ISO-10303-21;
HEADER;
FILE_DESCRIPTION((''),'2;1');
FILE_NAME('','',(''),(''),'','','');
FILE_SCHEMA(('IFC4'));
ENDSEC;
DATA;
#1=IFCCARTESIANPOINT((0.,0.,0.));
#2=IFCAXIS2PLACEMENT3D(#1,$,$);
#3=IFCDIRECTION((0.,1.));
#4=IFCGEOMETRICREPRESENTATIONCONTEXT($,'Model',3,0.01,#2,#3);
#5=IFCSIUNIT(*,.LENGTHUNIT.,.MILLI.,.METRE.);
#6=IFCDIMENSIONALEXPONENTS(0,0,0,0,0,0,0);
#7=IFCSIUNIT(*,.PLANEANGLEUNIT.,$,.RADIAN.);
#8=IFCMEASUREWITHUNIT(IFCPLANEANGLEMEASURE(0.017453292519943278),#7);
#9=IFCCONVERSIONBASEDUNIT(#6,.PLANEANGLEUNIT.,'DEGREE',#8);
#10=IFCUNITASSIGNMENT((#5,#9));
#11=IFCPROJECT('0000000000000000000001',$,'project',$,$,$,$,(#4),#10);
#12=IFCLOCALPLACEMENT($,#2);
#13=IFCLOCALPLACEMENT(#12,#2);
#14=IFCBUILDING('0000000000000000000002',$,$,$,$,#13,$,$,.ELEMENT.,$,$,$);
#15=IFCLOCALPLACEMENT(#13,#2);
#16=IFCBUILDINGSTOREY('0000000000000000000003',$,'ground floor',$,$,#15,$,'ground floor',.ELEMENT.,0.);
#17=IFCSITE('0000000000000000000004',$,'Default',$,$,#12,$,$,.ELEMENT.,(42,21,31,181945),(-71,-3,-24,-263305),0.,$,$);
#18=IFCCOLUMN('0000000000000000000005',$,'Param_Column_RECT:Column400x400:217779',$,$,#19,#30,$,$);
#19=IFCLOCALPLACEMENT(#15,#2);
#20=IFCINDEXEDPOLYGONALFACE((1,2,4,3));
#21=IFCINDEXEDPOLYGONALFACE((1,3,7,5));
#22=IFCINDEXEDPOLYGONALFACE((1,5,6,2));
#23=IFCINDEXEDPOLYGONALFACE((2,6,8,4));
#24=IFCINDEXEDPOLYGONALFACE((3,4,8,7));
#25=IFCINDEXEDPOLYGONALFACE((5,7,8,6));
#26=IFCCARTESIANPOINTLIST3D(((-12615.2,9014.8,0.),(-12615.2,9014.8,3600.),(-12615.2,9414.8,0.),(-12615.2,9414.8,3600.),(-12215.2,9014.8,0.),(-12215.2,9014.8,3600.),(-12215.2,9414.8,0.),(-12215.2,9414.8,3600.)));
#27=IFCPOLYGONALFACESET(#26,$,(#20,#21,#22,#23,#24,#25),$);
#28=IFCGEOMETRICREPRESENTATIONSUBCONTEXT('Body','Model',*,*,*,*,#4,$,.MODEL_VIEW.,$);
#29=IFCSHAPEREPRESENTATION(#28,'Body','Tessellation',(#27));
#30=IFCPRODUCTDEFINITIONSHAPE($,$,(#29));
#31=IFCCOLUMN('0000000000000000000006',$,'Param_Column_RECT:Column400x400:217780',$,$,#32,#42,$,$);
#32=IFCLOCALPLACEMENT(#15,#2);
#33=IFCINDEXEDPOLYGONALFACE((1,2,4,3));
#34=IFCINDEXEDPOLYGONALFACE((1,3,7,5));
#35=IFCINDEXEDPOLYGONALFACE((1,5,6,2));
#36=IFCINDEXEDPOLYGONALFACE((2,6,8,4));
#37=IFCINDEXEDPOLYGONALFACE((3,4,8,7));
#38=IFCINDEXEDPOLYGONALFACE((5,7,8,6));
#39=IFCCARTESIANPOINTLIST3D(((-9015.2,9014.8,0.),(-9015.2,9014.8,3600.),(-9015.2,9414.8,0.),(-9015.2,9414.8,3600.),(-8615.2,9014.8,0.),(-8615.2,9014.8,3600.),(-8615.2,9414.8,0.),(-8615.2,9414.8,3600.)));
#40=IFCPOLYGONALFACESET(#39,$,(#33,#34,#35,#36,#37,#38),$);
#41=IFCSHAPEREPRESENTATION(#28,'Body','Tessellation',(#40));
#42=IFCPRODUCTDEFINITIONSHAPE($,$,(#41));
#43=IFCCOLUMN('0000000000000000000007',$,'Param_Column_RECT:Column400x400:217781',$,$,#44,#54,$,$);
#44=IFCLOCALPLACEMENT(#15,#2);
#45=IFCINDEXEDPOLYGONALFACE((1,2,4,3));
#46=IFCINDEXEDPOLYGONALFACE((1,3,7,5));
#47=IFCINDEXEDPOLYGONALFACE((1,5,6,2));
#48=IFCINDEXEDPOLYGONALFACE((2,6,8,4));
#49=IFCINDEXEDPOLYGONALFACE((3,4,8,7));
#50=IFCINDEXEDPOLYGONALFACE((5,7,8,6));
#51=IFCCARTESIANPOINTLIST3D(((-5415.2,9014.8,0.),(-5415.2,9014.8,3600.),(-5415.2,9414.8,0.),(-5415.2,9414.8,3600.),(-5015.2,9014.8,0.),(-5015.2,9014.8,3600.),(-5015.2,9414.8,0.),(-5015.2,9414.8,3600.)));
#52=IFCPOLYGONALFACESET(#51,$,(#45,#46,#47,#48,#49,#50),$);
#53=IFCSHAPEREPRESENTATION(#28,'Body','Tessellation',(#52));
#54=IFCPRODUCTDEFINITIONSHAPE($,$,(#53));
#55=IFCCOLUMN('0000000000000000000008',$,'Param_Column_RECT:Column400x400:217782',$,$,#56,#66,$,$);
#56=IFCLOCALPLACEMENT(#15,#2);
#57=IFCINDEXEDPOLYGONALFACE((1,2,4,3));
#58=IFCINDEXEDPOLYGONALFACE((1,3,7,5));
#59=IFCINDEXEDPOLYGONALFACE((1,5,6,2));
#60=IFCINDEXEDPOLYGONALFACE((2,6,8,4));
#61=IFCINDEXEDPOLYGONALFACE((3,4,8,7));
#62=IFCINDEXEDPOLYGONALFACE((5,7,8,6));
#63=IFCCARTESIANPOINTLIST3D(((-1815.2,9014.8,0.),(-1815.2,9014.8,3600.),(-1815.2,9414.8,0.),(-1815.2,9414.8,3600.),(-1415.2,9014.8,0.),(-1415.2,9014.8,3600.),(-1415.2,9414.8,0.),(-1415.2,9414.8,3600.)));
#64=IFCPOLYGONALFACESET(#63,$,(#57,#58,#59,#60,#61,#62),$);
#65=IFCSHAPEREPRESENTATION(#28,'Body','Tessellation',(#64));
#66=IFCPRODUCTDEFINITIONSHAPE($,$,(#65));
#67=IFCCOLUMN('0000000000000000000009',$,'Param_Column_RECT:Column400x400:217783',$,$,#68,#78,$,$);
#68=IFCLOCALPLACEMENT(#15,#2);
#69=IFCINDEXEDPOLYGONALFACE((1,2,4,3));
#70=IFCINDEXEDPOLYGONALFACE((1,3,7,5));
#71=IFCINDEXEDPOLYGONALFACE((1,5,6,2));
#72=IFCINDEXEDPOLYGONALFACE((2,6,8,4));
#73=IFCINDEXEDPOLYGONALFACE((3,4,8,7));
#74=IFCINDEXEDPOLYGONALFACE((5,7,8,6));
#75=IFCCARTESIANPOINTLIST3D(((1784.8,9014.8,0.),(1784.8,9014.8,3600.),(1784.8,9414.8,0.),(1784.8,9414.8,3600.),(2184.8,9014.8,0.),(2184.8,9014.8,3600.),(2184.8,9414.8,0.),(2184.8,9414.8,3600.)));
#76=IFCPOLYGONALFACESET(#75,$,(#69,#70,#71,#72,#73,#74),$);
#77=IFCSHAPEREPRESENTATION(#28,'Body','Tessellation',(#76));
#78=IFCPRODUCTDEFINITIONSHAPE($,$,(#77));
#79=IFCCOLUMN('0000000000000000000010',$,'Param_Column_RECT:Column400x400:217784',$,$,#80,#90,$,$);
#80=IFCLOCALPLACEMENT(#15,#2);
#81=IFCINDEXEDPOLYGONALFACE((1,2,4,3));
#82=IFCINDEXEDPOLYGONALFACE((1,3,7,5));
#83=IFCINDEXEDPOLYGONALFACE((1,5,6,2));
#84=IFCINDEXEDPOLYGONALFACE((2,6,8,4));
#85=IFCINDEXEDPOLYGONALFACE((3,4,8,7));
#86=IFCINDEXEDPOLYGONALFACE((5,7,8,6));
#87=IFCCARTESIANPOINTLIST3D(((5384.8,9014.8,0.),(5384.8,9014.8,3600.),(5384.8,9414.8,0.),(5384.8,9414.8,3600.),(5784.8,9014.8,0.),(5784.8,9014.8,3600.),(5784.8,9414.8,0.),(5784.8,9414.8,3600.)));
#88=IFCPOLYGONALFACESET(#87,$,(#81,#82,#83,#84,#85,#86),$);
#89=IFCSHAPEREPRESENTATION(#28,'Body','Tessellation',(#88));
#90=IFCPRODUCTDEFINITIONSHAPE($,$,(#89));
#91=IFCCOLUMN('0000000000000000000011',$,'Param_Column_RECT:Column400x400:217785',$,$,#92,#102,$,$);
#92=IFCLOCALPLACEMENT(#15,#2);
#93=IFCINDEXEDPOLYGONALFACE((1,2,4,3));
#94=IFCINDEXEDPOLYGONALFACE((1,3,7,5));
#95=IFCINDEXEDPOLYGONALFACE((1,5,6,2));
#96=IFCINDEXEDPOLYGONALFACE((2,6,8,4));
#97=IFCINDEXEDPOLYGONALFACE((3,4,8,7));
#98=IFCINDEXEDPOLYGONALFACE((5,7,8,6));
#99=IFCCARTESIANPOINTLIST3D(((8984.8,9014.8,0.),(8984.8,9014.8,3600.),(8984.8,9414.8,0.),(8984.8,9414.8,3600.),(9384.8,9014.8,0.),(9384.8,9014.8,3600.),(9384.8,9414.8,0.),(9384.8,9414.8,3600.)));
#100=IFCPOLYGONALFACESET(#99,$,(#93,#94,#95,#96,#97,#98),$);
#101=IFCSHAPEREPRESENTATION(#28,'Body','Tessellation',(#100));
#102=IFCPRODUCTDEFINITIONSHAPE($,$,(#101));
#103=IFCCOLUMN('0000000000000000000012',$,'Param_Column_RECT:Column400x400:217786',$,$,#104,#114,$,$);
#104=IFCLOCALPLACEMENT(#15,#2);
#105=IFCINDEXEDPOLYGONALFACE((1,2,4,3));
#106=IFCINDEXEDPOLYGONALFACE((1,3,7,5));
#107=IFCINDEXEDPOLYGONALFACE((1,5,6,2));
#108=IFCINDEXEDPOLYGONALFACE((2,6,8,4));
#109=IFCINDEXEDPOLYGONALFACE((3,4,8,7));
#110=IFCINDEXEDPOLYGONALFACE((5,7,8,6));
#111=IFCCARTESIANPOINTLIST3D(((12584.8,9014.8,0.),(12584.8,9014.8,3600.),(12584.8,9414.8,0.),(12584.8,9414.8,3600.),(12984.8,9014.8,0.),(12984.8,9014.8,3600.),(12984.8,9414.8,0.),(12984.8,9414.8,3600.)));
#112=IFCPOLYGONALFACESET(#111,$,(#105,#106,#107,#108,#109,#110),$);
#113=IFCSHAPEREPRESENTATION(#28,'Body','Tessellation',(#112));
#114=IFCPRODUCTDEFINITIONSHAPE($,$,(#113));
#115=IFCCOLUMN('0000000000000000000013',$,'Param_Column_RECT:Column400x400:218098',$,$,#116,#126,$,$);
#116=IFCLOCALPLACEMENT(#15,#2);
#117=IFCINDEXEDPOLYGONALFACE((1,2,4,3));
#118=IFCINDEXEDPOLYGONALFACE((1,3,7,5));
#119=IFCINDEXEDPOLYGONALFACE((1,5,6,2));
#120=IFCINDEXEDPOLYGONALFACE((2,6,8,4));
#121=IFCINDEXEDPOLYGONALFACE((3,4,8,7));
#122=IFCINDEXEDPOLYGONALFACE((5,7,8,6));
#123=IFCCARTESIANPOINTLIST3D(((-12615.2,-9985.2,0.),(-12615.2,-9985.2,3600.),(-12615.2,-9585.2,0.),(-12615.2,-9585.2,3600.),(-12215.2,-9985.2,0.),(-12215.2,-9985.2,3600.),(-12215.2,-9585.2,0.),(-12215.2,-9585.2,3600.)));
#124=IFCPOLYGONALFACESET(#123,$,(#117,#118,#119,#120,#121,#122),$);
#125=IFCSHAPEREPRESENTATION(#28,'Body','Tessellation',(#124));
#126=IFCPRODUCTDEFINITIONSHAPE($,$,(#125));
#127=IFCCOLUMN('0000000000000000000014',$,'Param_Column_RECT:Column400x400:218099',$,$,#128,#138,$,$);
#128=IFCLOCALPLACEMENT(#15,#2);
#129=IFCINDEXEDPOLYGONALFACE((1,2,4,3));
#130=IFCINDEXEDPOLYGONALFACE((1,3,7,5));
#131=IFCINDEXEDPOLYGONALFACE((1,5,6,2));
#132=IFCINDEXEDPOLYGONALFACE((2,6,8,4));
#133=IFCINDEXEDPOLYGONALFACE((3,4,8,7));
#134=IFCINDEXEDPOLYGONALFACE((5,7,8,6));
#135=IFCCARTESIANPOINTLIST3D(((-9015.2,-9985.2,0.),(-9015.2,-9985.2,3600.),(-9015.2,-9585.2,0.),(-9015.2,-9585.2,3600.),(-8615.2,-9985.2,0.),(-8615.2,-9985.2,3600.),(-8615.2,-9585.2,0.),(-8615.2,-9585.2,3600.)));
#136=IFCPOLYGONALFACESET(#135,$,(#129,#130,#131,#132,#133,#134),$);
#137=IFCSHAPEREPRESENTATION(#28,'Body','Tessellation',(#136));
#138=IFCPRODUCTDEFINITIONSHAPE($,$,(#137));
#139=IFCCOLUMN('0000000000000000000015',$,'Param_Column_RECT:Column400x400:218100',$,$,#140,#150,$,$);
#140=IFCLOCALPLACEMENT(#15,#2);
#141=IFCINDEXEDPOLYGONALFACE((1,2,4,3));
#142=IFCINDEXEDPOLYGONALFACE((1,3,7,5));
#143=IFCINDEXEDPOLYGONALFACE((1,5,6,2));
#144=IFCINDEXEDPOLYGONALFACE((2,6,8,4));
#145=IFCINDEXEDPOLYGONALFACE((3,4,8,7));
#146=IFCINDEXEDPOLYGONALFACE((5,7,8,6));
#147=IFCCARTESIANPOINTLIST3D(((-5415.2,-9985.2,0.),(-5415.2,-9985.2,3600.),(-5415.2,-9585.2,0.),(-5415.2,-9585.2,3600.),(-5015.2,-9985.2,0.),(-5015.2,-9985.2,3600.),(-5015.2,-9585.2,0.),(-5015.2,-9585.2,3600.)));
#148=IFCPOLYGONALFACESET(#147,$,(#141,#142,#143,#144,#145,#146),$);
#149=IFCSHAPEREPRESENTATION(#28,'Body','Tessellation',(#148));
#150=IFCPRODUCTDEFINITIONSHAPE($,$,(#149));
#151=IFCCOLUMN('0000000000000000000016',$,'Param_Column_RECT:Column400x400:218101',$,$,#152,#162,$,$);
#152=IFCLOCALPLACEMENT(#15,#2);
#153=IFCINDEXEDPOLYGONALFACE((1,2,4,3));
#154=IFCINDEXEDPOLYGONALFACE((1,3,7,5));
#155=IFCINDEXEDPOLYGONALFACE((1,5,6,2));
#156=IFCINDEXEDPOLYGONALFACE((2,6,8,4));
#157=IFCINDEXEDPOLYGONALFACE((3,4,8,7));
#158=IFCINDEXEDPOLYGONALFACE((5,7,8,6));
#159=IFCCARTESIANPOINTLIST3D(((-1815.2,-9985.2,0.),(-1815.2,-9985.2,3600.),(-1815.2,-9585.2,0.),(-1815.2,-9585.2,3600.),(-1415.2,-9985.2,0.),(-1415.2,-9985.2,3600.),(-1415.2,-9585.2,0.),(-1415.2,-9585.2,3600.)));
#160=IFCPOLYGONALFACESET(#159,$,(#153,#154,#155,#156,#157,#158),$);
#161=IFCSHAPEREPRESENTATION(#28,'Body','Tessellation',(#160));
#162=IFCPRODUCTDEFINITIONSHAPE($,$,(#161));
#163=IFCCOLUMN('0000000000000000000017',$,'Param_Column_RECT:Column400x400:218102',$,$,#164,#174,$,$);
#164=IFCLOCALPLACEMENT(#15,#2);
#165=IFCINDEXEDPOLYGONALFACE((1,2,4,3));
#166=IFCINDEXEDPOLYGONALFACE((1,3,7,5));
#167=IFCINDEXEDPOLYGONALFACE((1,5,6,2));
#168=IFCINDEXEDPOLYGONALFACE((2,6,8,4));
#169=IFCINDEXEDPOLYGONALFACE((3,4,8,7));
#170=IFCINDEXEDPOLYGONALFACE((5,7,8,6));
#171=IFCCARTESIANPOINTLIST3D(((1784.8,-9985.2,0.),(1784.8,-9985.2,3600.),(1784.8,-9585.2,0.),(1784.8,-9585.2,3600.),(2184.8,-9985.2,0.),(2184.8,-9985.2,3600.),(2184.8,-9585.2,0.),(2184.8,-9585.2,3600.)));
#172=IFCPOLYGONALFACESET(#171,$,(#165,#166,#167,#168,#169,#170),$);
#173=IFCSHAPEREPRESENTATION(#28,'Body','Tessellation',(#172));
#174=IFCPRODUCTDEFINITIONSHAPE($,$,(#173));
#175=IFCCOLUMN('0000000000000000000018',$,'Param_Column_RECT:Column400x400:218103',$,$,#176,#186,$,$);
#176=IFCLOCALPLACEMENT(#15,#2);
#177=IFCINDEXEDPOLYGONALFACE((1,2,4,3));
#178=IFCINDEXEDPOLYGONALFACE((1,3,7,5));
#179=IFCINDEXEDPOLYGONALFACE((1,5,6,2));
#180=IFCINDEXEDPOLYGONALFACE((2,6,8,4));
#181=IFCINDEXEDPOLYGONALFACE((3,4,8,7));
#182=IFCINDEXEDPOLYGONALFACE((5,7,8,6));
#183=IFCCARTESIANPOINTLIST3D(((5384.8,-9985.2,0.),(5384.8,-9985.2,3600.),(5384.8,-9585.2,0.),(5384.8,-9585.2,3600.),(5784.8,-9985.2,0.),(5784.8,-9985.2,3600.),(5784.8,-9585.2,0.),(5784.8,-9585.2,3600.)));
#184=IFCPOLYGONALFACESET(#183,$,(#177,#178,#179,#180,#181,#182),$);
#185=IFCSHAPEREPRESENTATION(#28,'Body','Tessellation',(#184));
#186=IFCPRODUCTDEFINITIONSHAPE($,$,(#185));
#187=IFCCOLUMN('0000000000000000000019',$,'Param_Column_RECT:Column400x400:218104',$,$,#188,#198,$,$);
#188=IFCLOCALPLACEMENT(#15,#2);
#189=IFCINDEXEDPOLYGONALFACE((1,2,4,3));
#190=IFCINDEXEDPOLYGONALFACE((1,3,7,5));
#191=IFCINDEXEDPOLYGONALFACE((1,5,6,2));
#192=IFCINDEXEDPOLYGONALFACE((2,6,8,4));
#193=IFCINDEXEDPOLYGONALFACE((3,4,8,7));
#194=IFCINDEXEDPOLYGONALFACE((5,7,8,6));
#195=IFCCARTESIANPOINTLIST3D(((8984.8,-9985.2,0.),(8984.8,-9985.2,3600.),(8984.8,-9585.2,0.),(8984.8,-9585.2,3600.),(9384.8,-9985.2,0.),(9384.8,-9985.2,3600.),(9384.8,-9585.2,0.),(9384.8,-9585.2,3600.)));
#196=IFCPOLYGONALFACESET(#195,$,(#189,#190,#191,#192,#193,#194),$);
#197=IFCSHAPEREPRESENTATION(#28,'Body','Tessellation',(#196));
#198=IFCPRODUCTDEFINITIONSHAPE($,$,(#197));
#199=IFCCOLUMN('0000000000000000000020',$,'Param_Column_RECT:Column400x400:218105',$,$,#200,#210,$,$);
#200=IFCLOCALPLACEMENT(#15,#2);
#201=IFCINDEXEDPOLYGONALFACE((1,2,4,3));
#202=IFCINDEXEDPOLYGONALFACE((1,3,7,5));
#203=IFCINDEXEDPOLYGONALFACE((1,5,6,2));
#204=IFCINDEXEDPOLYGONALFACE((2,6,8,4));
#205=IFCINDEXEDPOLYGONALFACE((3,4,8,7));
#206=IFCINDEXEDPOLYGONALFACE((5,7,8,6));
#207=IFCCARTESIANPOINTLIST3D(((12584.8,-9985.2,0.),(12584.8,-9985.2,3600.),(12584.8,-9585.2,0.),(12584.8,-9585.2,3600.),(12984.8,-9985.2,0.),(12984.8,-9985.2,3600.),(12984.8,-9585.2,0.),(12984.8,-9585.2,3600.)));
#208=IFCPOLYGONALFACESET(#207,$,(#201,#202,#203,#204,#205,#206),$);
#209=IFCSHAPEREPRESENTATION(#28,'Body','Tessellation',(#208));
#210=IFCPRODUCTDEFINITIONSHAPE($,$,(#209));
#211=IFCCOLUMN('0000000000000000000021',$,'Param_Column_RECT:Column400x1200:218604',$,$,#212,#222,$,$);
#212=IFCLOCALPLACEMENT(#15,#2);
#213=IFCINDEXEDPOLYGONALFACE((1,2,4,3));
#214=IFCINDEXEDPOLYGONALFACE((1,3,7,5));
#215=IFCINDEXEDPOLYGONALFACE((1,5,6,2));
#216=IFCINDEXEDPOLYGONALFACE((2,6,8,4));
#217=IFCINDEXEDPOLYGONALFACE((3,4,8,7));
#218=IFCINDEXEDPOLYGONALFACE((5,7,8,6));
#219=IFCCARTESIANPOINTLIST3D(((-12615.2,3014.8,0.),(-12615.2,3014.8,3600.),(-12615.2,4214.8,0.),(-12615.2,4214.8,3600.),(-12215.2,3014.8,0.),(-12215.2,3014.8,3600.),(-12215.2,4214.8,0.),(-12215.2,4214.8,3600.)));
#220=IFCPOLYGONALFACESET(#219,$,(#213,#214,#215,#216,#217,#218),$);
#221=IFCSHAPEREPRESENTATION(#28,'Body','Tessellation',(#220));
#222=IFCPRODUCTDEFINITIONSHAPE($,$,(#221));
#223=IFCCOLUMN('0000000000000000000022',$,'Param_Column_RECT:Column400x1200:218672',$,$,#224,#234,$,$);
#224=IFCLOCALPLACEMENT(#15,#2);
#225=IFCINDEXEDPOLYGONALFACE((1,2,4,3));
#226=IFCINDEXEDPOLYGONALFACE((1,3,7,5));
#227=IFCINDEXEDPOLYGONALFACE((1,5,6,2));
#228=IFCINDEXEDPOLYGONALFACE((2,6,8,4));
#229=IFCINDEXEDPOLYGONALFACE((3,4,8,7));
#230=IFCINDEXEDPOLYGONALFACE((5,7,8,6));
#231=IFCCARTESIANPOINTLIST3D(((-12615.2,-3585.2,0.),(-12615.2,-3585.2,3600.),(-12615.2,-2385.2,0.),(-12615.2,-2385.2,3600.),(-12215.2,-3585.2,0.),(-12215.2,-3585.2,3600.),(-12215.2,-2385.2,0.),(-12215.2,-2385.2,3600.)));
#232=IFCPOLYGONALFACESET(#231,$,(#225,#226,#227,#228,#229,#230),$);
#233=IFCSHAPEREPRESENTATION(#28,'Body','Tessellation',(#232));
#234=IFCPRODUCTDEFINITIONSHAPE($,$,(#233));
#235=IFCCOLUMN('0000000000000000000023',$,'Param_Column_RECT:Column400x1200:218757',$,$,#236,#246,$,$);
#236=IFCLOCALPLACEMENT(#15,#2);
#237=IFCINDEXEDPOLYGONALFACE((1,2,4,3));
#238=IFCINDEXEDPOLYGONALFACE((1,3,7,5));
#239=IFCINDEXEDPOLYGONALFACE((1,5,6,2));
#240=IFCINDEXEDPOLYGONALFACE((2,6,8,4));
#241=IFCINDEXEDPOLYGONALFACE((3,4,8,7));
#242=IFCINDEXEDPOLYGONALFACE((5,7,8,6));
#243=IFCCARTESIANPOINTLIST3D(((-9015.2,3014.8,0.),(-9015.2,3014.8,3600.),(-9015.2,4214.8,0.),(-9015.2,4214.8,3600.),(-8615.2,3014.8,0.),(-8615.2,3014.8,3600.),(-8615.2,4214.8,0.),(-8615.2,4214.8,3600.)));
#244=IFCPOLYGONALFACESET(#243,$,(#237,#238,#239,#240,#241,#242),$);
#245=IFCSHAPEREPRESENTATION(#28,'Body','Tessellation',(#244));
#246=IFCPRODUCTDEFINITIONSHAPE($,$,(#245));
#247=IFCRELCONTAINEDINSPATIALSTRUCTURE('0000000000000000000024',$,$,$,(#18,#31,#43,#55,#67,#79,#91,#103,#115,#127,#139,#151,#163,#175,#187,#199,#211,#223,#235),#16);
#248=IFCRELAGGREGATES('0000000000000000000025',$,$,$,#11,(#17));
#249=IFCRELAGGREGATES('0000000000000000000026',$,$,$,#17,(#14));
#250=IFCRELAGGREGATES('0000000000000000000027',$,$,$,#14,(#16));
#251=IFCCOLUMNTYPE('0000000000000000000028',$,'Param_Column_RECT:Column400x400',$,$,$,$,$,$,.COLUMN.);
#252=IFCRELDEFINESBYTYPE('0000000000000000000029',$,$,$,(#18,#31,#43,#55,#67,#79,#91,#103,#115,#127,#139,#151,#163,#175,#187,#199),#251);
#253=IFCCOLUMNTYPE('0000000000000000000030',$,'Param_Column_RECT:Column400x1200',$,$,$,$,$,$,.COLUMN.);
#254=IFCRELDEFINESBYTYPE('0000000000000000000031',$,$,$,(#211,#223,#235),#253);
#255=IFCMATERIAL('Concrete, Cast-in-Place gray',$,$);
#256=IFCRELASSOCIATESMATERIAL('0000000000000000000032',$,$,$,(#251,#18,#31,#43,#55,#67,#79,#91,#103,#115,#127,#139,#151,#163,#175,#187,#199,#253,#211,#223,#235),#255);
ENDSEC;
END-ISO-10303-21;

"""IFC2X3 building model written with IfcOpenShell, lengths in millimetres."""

from ifc_helpers import new_model, entity, si_unit, converted_unit, direction, frame, origin, origin_2d_with_axis, place, context, subcontext, project, spatial, rectangle, extrude, source, transform, mapped, material, type_object, type_shapes, element, save


model = new_model("IFC2X3")

# Units and contexts
model_context = context("Model", 3, precision=0.01, world=origin(), true_north=direction((0.0, 1.0)))
body_context = subcontext(model_context, "Body", "Model", "MODEL_VIEW")
ifc_project = project(units=[si_unit("LENGTHUNIT", "METRE", prefix="MILLI"), converted_unit("PLANEANGLEUNIT", "DEGREE", entity("IfcPlaneAngleMeasure", 0.017453292519943278), si_unit("PLANEANGLEUNIT", "RADIAN"), dimensions=[0, 0, 0, 0, 0, 0, 0])], contexts=[model_context])

# Site, building, storey
site_placement = place(None, origin())
site = spatial("IfcSite", under=ifc_project, at=site_placement, Name="Default", CompositionType="ELEMENT", RefLatitude=(42, 21, 31, 181945), RefLongitude=(-71, -3, -24, -263305), RefElevation=0.0)
building_placement = place(site_placement, origin())
building = spatial("IfcBuilding", under=site, at=building_placement, CompositionType="ELEMENT")
storey_placement = place(building_placement, origin())
storey = spatial("IfcBuildingStorey", under=building, at=storey_placement, Name="ground floor", LongName="ground floor", CompositionType="ELEMENT", Elevation=0.0)

# Columns
ifc_material_1 = material(Name="Concrete, Cast-in-Place gray")
column_type_1 = type_object("IfcColumnType", Name="Param_Column_RECT:Column400x400", PredefinedType="COLUMN", material=ifc_material_1)
shared_shape_1 = source(origin(), body_context, "Body", "SweptSolid", [
    extrude(rectangle(XDim=400.0, YDim=400.0, at=origin_2d_with_axis()), frame((0.0, 0.0, 0.0), z_axis=(0.0, 0.0, 1.0), x_axis=(-1.0, 0.0, 0.0)), (0.0, 0.0, 1.0), 3600.0),
])
type_shapes(column_type_1, [shared_shape_1])
for number, where, name in (
    (1, (-12415.2, 9214.8, 0.0), "Param_Column_RECT:Column400x400:217779"),
    (2, (-8815.2, 9214.8, 0.0), "Param_Column_RECT:Column400x400:217780"),
    (3, (-5215.2, 9214.8, 0.0), "Param_Column_RECT:Column400x400:217781"),
    (4, (-1615.2, 9214.8, 0.0), "Param_Column_RECT:Column400x400:217782"),
    (5, (1984.8, 9214.8, 0.0), "Param_Column_RECT:Column400x400:217783"),
    (6, (5584.8, 9214.8, 0.0), "Param_Column_RECT:Column400x400:217784"),
    (7, (9184.8, 9214.8, 0.0), "Param_Column_RECT:Column400x400:217785"),
    (8, (12784.8, 9214.8, 0.0), "Param_Column_RECT:Column400x400:217786"),
    (9, (-12415.2, -9785.2, 0.0), "Param_Column_RECT:Column400x400:218098"),
    (10, (-8815.2, -9785.2, 0.0), "Param_Column_RECT:Column400x400:218099"),
    (11, (-5215.2, -9785.2, 0.0), "Param_Column_RECT:Column400x400:218100"),
    (12, (-1615.2, -9785.2, 0.0), "Param_Column_RECT:Column400x400:218101"),
    (13, (1984.8, -9785.2, 0.0), "Param_Column_RECT:Column400x400:218102"),
    (14, (5584.8, -9785.2, 0.0), "Param_Column_RECT:Column400x400:218103"),
    (15, (9184.8, -9785.2, 0.0), "Param_Column_RECT:Column400x400:218104"),
    (16, (12784.8, -9785.2, 0.0), "Param_Column_RECT:Column400x400:218105"),
):
    element("IfcColumn", number, at=place(storey_placement, frame(where)), inside=storey, type_object=column_type_1, material=ifc_material_1, Name=name, context=body_context, shape_type="MappedRepresentation", body=[
        mapped(shared_shape_1, transform((0.0, 0.0, 0.0), scale=1.0)),
    ])
column_type_2 = type_object("IfcColumnType", Name="Param_Column_RECT:Column400x1200", PredefinedType="COLUMN", material=ifc_material_1)
shared_shape_2 = source(origin(), body_context, "Body", "SweptSolid", [
    extrude(rectangle(XDim=400.0, YDim=1200.0, at=origin_2d_with_axis()), frame((0.0, 0.0, 0.0), z_axis=(0.0, 0.0, 1.0), x_axis=(-1.0, 0.0, 0.0)), (0.0, 0.0, 1.0), 3600.0),
])
type_shapes(column_type_2, [shared_shape_2])
for number, where, name in (
    (17, (-12415.2, 3614.8, 0.0), "Param_Column_RECT:Column400x1200:218604"),
    (18, (-12415.2, -2985.2, 0.0), "Param_Column_RECT:Column400x1200:218672"),
    (19, (-8815.2, 3614.8, 0.0), "Param_Column_RECT:Column400x1200:218757"),
):
    element("IfcColumn", number, at=place(storey_placement, frame(where)), inside=storey, type_object=column_type_2, material=ifc_material_1, Name=name, context=body_context, shape_type="MappedRepresentation", body=[
        mapped(shared_shape_2, transform((0.0, 0.0, 0.0), scale=1.0)),
    ])

save(model, "model.ifc")
